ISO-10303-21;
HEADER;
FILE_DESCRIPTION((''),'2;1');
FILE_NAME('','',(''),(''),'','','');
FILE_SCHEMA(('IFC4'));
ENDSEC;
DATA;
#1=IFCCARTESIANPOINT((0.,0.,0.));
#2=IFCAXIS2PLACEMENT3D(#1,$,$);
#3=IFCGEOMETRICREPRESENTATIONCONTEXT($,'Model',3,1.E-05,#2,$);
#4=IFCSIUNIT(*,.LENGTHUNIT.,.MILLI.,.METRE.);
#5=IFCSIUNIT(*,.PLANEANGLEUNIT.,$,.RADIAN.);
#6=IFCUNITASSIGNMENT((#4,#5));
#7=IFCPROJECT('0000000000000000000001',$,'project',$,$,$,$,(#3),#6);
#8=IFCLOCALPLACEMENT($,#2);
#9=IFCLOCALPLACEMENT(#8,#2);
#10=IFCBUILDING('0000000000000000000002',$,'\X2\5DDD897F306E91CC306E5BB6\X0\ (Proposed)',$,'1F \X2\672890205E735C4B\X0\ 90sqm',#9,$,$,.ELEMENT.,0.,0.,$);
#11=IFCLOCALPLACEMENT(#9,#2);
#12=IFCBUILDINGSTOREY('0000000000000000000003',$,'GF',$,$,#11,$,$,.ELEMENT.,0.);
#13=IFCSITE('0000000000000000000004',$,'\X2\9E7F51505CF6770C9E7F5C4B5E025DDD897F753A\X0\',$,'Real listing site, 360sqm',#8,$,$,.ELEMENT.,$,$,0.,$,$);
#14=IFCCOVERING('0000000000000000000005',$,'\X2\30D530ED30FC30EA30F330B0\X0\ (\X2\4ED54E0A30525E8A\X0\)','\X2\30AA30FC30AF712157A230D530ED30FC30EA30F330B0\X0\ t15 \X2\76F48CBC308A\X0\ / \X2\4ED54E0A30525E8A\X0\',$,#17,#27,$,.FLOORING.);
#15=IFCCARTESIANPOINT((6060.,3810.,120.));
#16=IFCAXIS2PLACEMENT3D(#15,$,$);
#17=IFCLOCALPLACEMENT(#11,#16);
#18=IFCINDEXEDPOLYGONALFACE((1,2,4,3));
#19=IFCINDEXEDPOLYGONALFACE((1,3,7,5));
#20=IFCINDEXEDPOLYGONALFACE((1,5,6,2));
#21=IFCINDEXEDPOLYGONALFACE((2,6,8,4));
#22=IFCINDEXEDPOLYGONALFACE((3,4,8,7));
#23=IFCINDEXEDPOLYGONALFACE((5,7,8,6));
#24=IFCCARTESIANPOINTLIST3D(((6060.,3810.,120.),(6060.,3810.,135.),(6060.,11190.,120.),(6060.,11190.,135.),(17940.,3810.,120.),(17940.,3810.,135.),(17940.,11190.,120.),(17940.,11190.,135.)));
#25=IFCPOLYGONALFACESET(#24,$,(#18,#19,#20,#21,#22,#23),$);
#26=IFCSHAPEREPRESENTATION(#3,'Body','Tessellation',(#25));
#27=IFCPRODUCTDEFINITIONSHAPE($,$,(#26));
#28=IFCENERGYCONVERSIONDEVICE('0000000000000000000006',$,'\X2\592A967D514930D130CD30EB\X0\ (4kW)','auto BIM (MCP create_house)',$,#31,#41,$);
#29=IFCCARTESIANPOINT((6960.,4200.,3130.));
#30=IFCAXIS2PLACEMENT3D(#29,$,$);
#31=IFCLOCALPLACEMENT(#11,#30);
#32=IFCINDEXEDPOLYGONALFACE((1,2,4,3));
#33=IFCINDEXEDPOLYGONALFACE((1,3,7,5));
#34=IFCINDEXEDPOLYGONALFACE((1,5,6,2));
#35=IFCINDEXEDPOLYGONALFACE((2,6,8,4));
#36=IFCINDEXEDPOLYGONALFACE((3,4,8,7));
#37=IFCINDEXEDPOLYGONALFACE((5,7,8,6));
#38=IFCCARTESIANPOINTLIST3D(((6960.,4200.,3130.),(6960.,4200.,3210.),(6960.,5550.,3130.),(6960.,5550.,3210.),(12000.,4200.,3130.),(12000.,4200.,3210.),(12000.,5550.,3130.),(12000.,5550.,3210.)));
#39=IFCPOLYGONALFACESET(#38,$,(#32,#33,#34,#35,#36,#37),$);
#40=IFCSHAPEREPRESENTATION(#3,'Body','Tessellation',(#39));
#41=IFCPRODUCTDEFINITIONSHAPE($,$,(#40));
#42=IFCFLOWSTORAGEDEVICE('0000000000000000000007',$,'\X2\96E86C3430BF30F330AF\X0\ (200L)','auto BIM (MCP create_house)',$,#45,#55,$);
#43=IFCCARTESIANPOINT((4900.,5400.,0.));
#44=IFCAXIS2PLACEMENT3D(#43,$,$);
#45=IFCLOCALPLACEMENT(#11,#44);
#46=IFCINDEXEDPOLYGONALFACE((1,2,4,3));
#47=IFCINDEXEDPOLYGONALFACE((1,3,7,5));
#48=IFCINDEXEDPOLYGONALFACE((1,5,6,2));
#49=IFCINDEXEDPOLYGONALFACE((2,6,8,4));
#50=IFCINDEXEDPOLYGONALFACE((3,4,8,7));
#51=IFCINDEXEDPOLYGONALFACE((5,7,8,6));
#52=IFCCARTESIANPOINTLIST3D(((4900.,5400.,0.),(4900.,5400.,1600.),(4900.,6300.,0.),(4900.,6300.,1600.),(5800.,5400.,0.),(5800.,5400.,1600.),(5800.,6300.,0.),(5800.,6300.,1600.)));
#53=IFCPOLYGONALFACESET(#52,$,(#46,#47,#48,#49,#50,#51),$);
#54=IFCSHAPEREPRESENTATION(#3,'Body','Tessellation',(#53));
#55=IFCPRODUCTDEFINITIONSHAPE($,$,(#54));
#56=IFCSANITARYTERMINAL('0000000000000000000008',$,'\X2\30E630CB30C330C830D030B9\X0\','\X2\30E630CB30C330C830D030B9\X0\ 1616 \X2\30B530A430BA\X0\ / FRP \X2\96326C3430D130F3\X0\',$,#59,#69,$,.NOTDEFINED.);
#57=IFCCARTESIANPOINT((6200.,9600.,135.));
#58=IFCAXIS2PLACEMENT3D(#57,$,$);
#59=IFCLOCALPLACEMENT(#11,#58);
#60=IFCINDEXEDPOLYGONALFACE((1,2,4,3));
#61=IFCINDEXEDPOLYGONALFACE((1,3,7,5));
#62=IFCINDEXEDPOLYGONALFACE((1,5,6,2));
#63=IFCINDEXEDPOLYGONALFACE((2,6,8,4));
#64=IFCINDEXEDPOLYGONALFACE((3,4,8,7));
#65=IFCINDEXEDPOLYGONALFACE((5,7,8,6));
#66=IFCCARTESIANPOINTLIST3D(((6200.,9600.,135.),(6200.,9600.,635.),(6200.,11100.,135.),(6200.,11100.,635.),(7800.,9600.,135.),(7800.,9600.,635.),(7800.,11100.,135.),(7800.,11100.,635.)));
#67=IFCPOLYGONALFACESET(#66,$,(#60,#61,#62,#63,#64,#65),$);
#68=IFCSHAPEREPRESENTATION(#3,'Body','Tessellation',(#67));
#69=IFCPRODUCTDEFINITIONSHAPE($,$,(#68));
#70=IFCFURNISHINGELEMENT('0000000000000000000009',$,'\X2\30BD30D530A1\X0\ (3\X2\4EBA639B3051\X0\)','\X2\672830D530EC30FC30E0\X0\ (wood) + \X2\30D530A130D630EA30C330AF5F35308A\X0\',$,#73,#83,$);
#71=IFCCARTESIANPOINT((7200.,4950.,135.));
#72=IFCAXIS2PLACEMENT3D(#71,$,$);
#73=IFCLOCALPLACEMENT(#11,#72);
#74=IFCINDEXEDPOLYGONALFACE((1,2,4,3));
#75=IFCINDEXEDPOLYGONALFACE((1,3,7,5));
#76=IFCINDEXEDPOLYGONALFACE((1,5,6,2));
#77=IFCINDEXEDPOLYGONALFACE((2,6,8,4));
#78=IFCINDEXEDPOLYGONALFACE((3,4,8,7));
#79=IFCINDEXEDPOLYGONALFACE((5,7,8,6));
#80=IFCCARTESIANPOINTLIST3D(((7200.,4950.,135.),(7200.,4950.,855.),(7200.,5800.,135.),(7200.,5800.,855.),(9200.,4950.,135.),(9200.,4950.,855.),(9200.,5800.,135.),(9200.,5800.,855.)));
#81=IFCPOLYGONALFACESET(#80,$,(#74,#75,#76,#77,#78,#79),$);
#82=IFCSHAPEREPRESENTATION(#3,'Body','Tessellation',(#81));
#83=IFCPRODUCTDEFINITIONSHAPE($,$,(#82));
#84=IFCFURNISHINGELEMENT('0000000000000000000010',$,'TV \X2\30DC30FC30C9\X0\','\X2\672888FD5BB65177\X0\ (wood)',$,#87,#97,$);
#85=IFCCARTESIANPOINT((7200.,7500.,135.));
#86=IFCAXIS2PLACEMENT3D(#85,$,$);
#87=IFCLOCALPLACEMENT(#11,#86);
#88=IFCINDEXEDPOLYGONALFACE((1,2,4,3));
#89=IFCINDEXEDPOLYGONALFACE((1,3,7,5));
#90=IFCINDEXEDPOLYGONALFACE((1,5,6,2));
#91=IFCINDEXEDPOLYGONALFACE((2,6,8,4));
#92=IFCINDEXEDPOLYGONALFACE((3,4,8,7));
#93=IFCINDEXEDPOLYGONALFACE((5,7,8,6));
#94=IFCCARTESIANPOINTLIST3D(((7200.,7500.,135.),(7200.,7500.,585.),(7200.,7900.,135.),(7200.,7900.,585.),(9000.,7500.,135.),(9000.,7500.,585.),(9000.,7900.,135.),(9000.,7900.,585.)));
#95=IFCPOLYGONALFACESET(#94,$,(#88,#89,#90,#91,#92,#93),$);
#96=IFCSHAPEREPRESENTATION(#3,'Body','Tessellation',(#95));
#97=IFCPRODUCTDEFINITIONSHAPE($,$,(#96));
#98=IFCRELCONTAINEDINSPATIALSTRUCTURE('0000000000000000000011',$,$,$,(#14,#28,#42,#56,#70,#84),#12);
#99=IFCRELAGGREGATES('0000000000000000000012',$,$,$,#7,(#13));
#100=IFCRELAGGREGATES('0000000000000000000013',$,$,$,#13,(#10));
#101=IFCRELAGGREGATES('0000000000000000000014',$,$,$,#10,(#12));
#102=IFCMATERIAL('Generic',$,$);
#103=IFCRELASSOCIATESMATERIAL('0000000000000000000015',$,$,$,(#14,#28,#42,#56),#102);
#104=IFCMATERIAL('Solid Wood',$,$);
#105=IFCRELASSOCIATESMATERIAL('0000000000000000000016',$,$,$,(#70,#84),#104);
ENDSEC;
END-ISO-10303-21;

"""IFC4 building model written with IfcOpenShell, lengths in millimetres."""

from ifc_helpers import new_model, si_unit, frame, frame_2d, origin, place, context, project, spatial, rectangle, extrude, material, element, save


model = new_model("IFC4")

# Units and contexts
model_context = context("Model", 3, precision=1e-05, world=origin())
ifc_project = project(units=[si_unit("LENGTHUNIT", "METRE", prefix="MILLI"), si_unit("PLANEANGLEUNIT", "RADIAN")], contexts=[model_context])

# Site, building, storey
site_placement = place(None, origin())
site = spatial("IfcSite", under=ifc_project, at=site_placement, Name="鹿児島県鹿屋市川西町", ObjectType="Real listing site, 360sqm", CompositionType="ELEMENT", RefElevation=0.0)
building_placement = place(site_placement, origin())
building = spatial("IfcBuilding", under=site, at=building_placement, Name="川西の里の家 (Proposed)", ObjectType="1F 木造平屋 90sqm", CompositionType="ELEMENT", ElevationOfRefHeight=0.0, ElevationOfTerrain=0.0)
storey_placement = place(building_placement, origin())
storey = spatial("IfcBuildingStorey", under=building, at=storey_placement, Name="GF", CompositionType="ELEMENT", Elevation=0.0)

# Shared definitions
ifc_material_1 = material(Name="Solid Wood")

# Covering
ifc_material_2 = material(Name="Generic")
covering_placement = place(storey_placement, frame((6060.0, 3810.0, 120.0)))
element("IfcCovering", 1, at=covering_placement, inside=storey, material=ifc_material_2, Name="フローリング (仕上げ床)", Description="オーク無垢フローリング t15 直貼り / 仕上げ床", PredefinedType="FLOORING", context=model_context, shape_type="SweptSolid", body=[
    extrude(rectangle(XDim=11880.0, YDim=7380.0, at=frame_2d((5940.0, 3690.0))), frame((6060.0, 3810.0, 120.0)), (0.0, 0.0, 1.0), 15.0),
])

# Energy conversion device
energy_conversion_device_placement = place(storey_placement, frame((6960.0, 4200.0, 3130.0)))
element("IfcEnergyConversionDevice", 2, at=energy_conversion_device_placement, inside=storey, material=ifc_material_2, Name="太陽光パネル (4kW)", Description="auto BIM (MCP create_house)", context=model_context, shape_type="SweptSolid", body=[
    extrude(rectangle(XDim=5040.0, YDim=1350.0, at=frame_2d((2520.0, 675.0))), frame((6960.0, 4200.0, 3130.0)), (0.0, 0.0, 1.0), 80.0),
])

# Flow storage device
flow_storage_device_placement = place(storey_placement, frame((4900.0, 5400.0, 0.0)))
element("IfcFlowStorageDevice", 3, at=flow_storage_device_placement, inside=storey, material=ifc_material_2, Name="雨水タンク (200L)", Description="auto BIM (MCP create_house)", context=model_context, shape_type="SweptSolid", body=[
    extrude(rectangle(XDim=900.0, YDim=900.0, at=frame_2d((450.0, 450.0))), frame((4900.0, 5400.0, 0.0)), (0.0, 0.0, 1.0), 1600.0),
])

# Sanitary terminal
sanitary_terminal_placement = place(storey_placement, frame((6200.0, 9600.0, 135.0)))
element("IfcSanitaryTerminal", 4, at=sanitary_terminal_placement, inside=storey, material=ifc_material_2, Name="ユニットバス", Description="ユニットバス 1616 サイズ / FRP 防水パン", PredefinedType="NOTDEFINED", context=model_context, shape_type="SweptSolid", body=[
    extrude(rectangle(XDim=1600.0, YDim=1500.0, at=frame_2d((800.0, 750.0))), frame((6200.0, 9600.0, 135.0)), (0.0, 0.0, 1.0), 500.0),
])

# Furnishing elements
furnishing_1_placement = place(storey_placement, frame((7200.0, 4950.0, 135.0)))
element("IfcFurnishingElement", 5, at=furnishing_1_placement, inside=storey, material=ifc_material_1, Name="ソファ (3人掛け)", Description="木フレーム (wood) + ファブリック張り", context=model_context, shape_type="SweptSolid", body=[
    extrude(rectangle(XDim=2000.0, YDim=850.0, at=frame_2d((1000.0, 425.0))), frame((7200.0, 4950.0, 135.0)), (0.0, 0.0, 1.0), 720.0),
])
furnishing_2_placement = place(storey_placement, frame((7200.0, 7500.0, 135.0)))
element("IfcFurnishingElement", 6, at=furnishing_2_placement, inside=storey, material=ifc_material_1, Name="TV ボード", Description="木製家具 (wood)", context=model_context, shape_type="SweptSolid", body=[
    extrude(rectangle(XDim=1800.0, YDim=400.0, at=frame_2d((900.0, 200.0))), frame((7200.0, 7500.0, 135.0)), (0.0, 0.0, 1.0), 450.0),
])

save(model, "model.ifc")
